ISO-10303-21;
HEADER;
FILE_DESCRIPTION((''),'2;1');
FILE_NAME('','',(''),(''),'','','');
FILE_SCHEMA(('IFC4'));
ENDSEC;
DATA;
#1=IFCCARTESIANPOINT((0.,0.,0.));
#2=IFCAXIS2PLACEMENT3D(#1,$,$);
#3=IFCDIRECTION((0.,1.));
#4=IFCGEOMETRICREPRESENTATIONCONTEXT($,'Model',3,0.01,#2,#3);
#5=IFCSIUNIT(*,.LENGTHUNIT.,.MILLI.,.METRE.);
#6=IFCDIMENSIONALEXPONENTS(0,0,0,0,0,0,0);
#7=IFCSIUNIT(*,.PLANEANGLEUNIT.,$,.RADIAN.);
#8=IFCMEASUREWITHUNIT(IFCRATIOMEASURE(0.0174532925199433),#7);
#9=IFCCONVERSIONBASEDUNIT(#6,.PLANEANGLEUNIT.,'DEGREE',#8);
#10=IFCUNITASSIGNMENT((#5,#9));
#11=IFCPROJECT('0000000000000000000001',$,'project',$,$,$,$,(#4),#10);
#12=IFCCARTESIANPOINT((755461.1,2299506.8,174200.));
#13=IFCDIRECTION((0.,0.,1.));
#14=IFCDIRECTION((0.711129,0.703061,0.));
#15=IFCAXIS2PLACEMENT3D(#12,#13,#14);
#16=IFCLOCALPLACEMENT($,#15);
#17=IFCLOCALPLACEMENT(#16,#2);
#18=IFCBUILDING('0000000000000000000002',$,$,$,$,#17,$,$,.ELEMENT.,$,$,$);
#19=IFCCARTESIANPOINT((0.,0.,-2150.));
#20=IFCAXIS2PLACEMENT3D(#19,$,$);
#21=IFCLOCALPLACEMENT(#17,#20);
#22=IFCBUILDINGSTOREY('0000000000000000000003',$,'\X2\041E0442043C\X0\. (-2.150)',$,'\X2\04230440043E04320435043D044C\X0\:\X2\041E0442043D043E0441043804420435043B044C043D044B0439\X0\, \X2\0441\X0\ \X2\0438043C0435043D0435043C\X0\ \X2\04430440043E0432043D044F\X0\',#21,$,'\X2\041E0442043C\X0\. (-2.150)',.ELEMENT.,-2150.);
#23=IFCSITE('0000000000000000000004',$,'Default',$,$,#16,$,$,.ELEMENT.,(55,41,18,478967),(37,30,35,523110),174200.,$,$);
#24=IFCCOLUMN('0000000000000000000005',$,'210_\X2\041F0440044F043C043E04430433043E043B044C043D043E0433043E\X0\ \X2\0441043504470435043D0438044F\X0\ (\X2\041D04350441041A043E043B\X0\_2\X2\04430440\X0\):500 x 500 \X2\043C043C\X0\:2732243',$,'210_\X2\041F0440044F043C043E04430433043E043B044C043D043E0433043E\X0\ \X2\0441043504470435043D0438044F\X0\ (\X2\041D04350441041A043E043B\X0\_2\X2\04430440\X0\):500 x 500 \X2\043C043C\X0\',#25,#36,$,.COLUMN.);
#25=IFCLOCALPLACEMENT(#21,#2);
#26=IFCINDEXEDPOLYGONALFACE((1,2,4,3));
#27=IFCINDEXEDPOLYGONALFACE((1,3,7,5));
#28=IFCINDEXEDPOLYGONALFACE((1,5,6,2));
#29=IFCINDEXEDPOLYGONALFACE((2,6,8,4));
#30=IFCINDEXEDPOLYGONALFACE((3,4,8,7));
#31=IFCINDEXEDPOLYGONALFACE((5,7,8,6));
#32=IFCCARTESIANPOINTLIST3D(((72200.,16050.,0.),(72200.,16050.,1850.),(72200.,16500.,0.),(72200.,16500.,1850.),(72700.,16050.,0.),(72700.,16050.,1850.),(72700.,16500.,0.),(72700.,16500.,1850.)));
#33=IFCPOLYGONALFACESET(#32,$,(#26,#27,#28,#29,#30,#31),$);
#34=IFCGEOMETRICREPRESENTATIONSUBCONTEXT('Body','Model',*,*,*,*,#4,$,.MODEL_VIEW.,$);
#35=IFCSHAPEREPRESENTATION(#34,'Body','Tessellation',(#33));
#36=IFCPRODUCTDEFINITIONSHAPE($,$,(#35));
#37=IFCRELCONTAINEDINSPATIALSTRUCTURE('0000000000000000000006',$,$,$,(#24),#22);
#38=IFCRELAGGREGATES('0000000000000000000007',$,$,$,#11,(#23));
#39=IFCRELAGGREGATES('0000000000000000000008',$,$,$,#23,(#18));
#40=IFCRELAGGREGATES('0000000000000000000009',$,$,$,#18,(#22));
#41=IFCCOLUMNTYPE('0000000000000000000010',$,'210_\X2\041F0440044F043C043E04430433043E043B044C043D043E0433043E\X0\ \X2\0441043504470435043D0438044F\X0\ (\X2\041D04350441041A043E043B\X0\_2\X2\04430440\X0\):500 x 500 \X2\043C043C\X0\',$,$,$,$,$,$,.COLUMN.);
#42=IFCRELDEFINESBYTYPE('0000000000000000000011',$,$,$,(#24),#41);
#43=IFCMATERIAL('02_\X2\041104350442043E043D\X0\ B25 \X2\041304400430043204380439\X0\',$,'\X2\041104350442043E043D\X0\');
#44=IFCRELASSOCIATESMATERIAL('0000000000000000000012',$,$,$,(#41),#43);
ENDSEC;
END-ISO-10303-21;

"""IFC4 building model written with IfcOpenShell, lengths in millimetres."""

from ifc_helpers import new_model, entity, si_unit, converted_unit, direction, frame, origin, place, context, subcontext, project, spatial, indexed_curve, outline, extrude, source, transform, mapped, material, type_object, type_shapes, element, save


model = new_model("IFC4")

# Units and contexts
model_context = context("Model", 3, precision=0.01, world=origin(), true_north=direction((0.0, 1.0)))
body_context = subcontext(model_context, "Body", "Model", "MODEL_VIEW")
ifc_project = project(units=[si_unit("LENGTHUNIT", "METRE", prefix="MILLI"), converted_unit("PLANEANGLEUNIT", "DEGREE", entity("IfcRatioMeasure", 0.0174532925199433), si_unit("PLANEANGLEUNIT", "RADIAN"), dimensions=[0, 0, 0, 0, 0, 0, 0])], contexts=[model_context])

# Site, building, storey
site_placement = place(None, frame((755461.1, 2299506.8, 174200.0), z_axis=(0.0, 0.0, 1.0), x_axis=(0.711129, 0.703061, 0.0)))
site = spatial("IfcSite", under=ifc_project, at=site_placement, Name="Default", CompositionType="ELEMENT", RefLatitude=(55, 41, 18, 478967), RefLongitude=(37, 30, 35, 523110), RefElevation=174200.0)
building_placement = place(site_placement, origin())
building = spatial("IfcBuilding", under=site, at=building_placement, CompositionType="ELEMENT")
storey_placement = place(building_placement, frame((0.0, 0.0, -2150.0)))
storey = spatial("IfcBuildingStorey", under=building, at=storey_placement, Name="Отм. (-2.150)", ObjectType="Уровень:Относительный, с именем уровня", LongName="Отм. (-2.150)", CompositionType="ELEMENT", Elevation=-2150.0)

# Column
ifc_material_1 = material(Name="02_Бетон B25 Гравий", Category="Бетон")
column_type_1 = type_object("IfcColumnType", Name="210_Прямоугольного сечения (НесКол_2ур):500 x 500 мм", PredefinedType="COLUMN", material=ifc_material_1)
shared_shape_1 = source(origin(), body_context, "Body", "SweptSolid", [
    extrude(outline(indexed_curve([(-225.0, -250.0), (225.0, -250.0), (225.0, 250.0), (-225.0, 250.0), (-225.0, -250.0)], self_intersect=False)), frame((72450.0, 16275.0, -2150.0), z_axis=(0.0, 0.0, 1.0), x_axis=(0.0, -1.0, 0.0)), (0.0, 0.0, 1.0), 1850.0),
])
type_shapes(column_type_1, [shared_shape_1])
column_1_placement = place(storey_placement, frame((0.0, 0.0, 2150.0)))
element("IfcColumn", 1, at=column_1_placement, inside=storey, type_object=column_type_1, Name="210_Прямоугольного сечения (НесКол_2ур):500 x 500 мм:2732243", ObjectType="210_Прямоугольного сечения (НесКол_2ур):500 x 500 мм", PredefinedType="COLUMN", context=body_context, shape_type="MappedRepresentation", body=[
    mapped(shared_shape_1, transform((0.0, 0.0, 0.0), scale=1.0)),
])

save(model, "model.ifc")
